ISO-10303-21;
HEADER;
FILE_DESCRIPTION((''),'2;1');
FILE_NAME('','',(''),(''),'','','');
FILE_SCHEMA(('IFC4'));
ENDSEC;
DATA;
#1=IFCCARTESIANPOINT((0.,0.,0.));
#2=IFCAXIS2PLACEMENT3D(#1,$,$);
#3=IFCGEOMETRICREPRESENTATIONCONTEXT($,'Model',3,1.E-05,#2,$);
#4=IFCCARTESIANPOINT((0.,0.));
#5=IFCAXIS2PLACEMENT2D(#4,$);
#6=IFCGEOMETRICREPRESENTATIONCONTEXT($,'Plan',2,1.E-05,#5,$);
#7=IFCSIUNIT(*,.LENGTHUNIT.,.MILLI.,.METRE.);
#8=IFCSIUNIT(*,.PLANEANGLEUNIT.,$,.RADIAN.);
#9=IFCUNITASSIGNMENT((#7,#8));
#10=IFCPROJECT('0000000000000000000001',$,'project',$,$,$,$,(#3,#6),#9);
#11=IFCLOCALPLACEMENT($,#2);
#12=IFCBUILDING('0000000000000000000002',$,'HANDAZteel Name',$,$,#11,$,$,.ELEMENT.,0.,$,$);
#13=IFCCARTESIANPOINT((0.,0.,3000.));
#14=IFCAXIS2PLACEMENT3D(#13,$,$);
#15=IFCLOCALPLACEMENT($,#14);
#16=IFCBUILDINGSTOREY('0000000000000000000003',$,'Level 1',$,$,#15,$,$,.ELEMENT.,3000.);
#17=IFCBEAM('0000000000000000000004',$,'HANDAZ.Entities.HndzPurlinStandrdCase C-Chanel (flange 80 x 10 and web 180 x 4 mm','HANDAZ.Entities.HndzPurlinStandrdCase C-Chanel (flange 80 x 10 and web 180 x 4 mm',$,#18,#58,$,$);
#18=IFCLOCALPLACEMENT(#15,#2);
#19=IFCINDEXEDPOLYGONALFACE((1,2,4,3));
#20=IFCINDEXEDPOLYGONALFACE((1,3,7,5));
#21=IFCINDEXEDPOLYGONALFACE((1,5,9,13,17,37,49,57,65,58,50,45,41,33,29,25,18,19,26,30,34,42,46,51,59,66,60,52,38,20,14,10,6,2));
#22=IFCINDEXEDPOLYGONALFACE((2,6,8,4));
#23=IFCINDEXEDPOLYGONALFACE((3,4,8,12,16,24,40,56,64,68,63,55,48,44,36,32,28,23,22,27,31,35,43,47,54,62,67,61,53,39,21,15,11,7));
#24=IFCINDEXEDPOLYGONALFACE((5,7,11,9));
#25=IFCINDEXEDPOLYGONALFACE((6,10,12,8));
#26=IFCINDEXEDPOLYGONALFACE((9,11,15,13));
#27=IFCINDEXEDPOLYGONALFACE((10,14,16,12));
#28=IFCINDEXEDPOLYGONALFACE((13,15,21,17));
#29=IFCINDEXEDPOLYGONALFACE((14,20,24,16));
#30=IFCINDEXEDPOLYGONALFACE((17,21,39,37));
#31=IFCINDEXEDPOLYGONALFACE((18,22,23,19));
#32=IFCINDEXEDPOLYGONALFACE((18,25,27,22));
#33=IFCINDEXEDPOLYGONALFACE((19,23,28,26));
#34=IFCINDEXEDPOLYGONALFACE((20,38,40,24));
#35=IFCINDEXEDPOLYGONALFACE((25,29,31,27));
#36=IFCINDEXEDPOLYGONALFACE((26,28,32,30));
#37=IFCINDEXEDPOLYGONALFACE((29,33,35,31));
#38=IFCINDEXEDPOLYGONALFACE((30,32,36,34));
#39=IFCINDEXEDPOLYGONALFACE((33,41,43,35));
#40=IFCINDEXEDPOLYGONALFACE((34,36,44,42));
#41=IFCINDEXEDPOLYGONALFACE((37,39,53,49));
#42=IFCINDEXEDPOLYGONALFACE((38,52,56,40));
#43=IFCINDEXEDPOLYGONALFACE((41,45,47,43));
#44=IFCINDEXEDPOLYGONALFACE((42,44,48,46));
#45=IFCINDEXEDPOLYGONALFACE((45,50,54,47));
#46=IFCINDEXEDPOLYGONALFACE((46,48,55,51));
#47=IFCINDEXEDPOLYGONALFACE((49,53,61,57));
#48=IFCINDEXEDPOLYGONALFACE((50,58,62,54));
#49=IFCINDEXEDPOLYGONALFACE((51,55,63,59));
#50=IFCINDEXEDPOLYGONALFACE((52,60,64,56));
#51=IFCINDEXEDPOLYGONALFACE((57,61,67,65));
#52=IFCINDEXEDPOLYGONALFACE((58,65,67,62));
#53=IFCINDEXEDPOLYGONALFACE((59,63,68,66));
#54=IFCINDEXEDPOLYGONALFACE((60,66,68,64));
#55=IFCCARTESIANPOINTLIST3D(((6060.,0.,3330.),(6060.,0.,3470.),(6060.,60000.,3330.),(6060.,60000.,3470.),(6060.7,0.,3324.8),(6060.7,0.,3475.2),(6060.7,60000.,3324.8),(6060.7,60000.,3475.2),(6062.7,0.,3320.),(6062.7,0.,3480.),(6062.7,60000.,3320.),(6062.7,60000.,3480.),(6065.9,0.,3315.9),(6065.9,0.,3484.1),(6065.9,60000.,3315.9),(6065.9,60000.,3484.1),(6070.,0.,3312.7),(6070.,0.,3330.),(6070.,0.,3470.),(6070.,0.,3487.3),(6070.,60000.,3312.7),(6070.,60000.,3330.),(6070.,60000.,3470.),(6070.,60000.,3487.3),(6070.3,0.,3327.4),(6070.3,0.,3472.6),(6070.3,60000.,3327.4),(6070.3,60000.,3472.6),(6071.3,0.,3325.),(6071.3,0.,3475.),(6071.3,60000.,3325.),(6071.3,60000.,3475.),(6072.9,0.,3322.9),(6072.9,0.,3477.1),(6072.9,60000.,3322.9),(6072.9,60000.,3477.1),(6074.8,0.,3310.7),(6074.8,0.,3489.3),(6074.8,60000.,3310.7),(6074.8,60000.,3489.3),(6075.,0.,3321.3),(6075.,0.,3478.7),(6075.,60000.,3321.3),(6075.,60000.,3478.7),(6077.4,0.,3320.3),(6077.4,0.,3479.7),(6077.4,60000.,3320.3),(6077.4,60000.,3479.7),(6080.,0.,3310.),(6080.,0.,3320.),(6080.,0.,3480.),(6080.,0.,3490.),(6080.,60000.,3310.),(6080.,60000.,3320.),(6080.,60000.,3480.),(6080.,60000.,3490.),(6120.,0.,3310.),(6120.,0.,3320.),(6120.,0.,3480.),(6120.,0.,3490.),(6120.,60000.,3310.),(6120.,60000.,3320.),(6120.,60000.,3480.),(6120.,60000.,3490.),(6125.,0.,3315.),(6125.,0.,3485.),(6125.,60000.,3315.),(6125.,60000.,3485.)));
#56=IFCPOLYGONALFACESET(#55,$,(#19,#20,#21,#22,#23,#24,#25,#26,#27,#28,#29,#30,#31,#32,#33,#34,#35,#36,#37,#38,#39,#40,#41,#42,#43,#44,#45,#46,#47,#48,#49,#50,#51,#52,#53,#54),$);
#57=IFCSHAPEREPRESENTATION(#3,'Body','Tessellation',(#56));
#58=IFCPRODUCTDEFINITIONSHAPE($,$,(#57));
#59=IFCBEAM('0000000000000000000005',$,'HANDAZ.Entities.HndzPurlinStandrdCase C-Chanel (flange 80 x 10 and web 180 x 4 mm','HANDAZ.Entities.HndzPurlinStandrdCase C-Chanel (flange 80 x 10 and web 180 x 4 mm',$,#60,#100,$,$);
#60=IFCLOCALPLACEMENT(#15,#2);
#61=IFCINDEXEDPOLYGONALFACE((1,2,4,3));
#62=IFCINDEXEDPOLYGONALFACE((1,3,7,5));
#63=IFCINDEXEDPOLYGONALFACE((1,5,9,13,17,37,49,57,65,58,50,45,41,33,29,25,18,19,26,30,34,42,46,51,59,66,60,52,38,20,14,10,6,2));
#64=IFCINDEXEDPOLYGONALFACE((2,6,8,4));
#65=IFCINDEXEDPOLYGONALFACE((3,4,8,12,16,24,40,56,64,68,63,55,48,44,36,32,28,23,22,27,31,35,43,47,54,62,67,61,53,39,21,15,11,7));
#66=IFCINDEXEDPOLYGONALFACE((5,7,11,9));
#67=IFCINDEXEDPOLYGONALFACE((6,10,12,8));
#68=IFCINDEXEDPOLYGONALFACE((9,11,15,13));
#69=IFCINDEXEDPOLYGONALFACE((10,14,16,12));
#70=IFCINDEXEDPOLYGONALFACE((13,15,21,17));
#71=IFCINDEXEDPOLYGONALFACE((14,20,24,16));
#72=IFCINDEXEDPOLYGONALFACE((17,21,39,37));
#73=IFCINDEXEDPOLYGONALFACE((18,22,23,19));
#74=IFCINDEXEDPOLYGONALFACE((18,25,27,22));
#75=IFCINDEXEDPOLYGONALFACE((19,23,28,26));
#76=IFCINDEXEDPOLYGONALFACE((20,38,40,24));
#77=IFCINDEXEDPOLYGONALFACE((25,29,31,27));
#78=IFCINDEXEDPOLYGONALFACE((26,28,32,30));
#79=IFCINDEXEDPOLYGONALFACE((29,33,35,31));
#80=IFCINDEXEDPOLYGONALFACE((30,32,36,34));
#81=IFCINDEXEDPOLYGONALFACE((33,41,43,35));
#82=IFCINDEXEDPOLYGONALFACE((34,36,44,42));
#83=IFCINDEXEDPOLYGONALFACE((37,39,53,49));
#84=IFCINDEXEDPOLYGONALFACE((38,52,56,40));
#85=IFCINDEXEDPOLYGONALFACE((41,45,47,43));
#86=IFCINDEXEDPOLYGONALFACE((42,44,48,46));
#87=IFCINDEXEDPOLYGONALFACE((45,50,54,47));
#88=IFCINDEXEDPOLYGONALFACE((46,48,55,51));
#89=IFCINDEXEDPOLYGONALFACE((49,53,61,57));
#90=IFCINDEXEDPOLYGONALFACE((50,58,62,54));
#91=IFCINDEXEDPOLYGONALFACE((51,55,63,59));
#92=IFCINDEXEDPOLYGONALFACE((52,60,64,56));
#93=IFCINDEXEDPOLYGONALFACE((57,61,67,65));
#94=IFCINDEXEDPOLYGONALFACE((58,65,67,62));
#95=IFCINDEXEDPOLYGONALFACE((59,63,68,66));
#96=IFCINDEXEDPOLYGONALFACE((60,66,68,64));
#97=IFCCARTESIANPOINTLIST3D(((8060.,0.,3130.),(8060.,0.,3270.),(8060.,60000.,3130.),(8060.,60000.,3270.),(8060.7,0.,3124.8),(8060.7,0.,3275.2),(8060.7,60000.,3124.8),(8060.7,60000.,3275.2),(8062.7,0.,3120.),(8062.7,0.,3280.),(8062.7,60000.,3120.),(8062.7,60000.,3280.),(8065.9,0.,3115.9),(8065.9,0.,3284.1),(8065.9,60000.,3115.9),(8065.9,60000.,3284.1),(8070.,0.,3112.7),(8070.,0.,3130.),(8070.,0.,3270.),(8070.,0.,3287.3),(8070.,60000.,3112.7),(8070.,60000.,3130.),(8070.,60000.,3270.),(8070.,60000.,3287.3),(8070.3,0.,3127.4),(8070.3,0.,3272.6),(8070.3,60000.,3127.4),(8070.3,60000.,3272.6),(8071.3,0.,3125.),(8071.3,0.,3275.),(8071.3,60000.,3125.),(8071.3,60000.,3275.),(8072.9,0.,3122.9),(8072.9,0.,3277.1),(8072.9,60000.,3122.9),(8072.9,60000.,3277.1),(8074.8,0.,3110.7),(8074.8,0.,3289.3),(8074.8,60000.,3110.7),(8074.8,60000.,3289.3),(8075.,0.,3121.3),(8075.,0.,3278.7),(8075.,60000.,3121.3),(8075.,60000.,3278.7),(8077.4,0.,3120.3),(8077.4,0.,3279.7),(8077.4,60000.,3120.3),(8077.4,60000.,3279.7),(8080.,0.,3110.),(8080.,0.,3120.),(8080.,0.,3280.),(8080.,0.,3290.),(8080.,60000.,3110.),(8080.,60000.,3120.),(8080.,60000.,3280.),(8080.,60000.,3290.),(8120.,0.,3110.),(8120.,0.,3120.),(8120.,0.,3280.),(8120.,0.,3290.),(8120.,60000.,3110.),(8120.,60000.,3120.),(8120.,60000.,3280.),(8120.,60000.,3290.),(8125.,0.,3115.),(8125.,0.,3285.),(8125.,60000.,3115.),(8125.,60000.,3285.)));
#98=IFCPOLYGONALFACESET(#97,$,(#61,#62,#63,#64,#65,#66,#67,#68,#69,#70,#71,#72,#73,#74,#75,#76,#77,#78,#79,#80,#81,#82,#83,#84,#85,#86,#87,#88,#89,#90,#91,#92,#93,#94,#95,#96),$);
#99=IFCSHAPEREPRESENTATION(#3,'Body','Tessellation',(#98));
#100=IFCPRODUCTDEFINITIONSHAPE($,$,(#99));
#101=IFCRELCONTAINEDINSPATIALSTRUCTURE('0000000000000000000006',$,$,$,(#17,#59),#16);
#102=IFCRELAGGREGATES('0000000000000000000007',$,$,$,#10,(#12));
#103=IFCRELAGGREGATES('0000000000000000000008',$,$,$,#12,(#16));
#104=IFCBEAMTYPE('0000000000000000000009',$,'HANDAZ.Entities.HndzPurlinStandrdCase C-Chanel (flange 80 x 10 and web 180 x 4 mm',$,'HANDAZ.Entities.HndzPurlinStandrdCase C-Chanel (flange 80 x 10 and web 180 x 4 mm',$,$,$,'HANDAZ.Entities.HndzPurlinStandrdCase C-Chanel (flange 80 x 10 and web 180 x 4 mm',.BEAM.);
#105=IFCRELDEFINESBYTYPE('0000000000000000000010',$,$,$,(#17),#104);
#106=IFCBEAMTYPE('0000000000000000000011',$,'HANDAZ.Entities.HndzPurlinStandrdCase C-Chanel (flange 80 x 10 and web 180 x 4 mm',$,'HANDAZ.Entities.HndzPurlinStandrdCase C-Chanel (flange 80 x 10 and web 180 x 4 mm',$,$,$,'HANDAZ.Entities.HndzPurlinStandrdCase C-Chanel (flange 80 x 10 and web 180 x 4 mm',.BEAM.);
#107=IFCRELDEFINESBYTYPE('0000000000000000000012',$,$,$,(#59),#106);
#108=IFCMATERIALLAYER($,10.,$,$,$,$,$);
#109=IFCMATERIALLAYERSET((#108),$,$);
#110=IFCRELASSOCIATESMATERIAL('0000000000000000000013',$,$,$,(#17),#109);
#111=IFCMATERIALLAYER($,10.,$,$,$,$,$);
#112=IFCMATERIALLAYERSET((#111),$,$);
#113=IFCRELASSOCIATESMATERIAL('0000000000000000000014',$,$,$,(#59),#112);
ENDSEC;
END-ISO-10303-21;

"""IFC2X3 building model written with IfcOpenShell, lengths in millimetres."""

from ifc_helpers import new_model, si_unit, frame, frame_2d, origin, origin_2d, place, context, project, spatial, c_section, extrude, layer, layer_set, layer_usage, type_object, element, save


model = new_model("IFC2X3")

# Units and contexts
model_context = context("Model", 3, precision=1e-05, world=origin())
plan_context = context("Plan", 2, precision=1e-05, world=origin_2d())
ifc_project = project(units=[si_unit("LENGTHUNIT", "METRE", prefix="MILLI"), si_unit("PLANEANGLEUNIT", "RADIAN")], contexts=[model_context, plan_context])

# Building, storey
building_placement = place(None, origin())
building = spatial("IfcBuilding", under=ifc_project, at=building_placement, Name="HANDAZteel Name", CompositionType="ELEMENT", ElevationOfRefHeight=0.0)
storey_placement = place(None, frame((0.0, 0.0, 3000.0)))
storey = spatial("IfcBuildingStorey", under=building, at=storey_placement, Name="Level 1", CompositionType="ELEMENT", Elevation=3000.0)

# Beams
ifc_layer_1 = layer(None, 10.0)
ifc_layer_set_1 = layer_set([ifc_layer_1])
ifc_layer_usage_1 = layer_usage(ifc_layer_set_1, "AXIS2", "NEGATIVE", 150.0)
beam_type_1 = type_object("IfcBeamType", Name="HANDAZ.Entities.HndzPurlinStandrdCase C-Chanel (flange 80 x 10 and web 180 x 4 mm", ApplicableOccurrence="HANDAZ.Entities.HndzPurlinStandrdCase C-Chanel (flange 80 x 10 and web 180 x 4 mm", ElementType="HANDAZ.Entities.HndzPurlinStandrdCase C-Chanel (flange 80 x 10 and web 180 x 4 mm", PredefinedType="BEAM")
beam_1_placement = place(None, frame((6100.0, 0.0, 6400.0), z_axis=(0.0, 1.0, 0.0), x_axis=(0.0, 0.0, 1.0)))
element("IfcBeam", 1, at=beam_1_placement, inside=storey, type_object=beam_type_1, material=ifc_layer_usage_1, Name="HANDAZ.Entities.HndzPurlinStandrdCase C-Chanel (flange 80 x 10 and web 180 x 4 mm", Description="HANDAZ.Entities.HndzPurlinStandrdCase C-Chanel (flange 80 x 10 and web 180 x 4 mm", context=model_context, shape_type="SweptSolid", body=[
    extrude(c_section(Depth=180.0, Width=80.0, WallThickness=10.0, Girth=5.0, InternalFilletRadius=10.0, at=frame_2d((0.0, 0.0), x_axis=(0.0, 1.0))), origin(), (0.0, 0.0, 1.0), 60000.0),
])
ifc_layer_2 = layer(None, 10.0)
ifc_layer_set_2 = layer_set([ifc_layer_2])
ifc_layer_usage_2 = layer_usage(ifc_layer_set_2, "AXIS2", "NEGATIVE", 150.0)
beam_type_2 = type_object("IfcBeamType", Name="HANDAZ.Entities.HndzPurlinStandrdCase C-Chanel (flange 80 x 10 and web 180 x 4 mm", ApplicableOccurrence="HANDAZ.Entities.HndzPurlinStandrdCase C-Chanel (flange 80 x 10 and web 180 x 4 mm", ElementType="HANDAZ.Entities.HndzPurlinStandrdCase C-Chanel (flange 80 x 10 and web 180 x 4 mm", PredefinedType="BEAM")
beam_2_placement = place(None, frame((8100.0, 0.0, 6200.0), z_axis=(0.0, 1.0, 0.0), x_axis=(0.0, 0.0, 1.0)))
element("IfcBeam", 2, at=beam_2_placement, inside=storey, type_object=beam_type_2, material=ifc_layer_usage_2, Name="HANDAZ.Entities.HndzPurlinStandrdCase C-Chanel (flange 80 x 10 and web 180 x 4 mm", Description="HANDAZ.Entities.HndzPurlinStandrdCase C-Chanel (flange 80 x 10 and web 180 x 4 mm", context=model_context, shape_type="SweptSolid", body=[
    extrude(c_section(Depth=180.0, Width=80.0, WallThickness=10.0, Girth=5.0, InternalFilletRadius=10.0, at=frame_2d((0.0, 0.0), x_axis=(0.0, 1.0))), origin(), (0.0, 0.0, 1.0), 60000.0),
])

save(model, "model.ifc")
